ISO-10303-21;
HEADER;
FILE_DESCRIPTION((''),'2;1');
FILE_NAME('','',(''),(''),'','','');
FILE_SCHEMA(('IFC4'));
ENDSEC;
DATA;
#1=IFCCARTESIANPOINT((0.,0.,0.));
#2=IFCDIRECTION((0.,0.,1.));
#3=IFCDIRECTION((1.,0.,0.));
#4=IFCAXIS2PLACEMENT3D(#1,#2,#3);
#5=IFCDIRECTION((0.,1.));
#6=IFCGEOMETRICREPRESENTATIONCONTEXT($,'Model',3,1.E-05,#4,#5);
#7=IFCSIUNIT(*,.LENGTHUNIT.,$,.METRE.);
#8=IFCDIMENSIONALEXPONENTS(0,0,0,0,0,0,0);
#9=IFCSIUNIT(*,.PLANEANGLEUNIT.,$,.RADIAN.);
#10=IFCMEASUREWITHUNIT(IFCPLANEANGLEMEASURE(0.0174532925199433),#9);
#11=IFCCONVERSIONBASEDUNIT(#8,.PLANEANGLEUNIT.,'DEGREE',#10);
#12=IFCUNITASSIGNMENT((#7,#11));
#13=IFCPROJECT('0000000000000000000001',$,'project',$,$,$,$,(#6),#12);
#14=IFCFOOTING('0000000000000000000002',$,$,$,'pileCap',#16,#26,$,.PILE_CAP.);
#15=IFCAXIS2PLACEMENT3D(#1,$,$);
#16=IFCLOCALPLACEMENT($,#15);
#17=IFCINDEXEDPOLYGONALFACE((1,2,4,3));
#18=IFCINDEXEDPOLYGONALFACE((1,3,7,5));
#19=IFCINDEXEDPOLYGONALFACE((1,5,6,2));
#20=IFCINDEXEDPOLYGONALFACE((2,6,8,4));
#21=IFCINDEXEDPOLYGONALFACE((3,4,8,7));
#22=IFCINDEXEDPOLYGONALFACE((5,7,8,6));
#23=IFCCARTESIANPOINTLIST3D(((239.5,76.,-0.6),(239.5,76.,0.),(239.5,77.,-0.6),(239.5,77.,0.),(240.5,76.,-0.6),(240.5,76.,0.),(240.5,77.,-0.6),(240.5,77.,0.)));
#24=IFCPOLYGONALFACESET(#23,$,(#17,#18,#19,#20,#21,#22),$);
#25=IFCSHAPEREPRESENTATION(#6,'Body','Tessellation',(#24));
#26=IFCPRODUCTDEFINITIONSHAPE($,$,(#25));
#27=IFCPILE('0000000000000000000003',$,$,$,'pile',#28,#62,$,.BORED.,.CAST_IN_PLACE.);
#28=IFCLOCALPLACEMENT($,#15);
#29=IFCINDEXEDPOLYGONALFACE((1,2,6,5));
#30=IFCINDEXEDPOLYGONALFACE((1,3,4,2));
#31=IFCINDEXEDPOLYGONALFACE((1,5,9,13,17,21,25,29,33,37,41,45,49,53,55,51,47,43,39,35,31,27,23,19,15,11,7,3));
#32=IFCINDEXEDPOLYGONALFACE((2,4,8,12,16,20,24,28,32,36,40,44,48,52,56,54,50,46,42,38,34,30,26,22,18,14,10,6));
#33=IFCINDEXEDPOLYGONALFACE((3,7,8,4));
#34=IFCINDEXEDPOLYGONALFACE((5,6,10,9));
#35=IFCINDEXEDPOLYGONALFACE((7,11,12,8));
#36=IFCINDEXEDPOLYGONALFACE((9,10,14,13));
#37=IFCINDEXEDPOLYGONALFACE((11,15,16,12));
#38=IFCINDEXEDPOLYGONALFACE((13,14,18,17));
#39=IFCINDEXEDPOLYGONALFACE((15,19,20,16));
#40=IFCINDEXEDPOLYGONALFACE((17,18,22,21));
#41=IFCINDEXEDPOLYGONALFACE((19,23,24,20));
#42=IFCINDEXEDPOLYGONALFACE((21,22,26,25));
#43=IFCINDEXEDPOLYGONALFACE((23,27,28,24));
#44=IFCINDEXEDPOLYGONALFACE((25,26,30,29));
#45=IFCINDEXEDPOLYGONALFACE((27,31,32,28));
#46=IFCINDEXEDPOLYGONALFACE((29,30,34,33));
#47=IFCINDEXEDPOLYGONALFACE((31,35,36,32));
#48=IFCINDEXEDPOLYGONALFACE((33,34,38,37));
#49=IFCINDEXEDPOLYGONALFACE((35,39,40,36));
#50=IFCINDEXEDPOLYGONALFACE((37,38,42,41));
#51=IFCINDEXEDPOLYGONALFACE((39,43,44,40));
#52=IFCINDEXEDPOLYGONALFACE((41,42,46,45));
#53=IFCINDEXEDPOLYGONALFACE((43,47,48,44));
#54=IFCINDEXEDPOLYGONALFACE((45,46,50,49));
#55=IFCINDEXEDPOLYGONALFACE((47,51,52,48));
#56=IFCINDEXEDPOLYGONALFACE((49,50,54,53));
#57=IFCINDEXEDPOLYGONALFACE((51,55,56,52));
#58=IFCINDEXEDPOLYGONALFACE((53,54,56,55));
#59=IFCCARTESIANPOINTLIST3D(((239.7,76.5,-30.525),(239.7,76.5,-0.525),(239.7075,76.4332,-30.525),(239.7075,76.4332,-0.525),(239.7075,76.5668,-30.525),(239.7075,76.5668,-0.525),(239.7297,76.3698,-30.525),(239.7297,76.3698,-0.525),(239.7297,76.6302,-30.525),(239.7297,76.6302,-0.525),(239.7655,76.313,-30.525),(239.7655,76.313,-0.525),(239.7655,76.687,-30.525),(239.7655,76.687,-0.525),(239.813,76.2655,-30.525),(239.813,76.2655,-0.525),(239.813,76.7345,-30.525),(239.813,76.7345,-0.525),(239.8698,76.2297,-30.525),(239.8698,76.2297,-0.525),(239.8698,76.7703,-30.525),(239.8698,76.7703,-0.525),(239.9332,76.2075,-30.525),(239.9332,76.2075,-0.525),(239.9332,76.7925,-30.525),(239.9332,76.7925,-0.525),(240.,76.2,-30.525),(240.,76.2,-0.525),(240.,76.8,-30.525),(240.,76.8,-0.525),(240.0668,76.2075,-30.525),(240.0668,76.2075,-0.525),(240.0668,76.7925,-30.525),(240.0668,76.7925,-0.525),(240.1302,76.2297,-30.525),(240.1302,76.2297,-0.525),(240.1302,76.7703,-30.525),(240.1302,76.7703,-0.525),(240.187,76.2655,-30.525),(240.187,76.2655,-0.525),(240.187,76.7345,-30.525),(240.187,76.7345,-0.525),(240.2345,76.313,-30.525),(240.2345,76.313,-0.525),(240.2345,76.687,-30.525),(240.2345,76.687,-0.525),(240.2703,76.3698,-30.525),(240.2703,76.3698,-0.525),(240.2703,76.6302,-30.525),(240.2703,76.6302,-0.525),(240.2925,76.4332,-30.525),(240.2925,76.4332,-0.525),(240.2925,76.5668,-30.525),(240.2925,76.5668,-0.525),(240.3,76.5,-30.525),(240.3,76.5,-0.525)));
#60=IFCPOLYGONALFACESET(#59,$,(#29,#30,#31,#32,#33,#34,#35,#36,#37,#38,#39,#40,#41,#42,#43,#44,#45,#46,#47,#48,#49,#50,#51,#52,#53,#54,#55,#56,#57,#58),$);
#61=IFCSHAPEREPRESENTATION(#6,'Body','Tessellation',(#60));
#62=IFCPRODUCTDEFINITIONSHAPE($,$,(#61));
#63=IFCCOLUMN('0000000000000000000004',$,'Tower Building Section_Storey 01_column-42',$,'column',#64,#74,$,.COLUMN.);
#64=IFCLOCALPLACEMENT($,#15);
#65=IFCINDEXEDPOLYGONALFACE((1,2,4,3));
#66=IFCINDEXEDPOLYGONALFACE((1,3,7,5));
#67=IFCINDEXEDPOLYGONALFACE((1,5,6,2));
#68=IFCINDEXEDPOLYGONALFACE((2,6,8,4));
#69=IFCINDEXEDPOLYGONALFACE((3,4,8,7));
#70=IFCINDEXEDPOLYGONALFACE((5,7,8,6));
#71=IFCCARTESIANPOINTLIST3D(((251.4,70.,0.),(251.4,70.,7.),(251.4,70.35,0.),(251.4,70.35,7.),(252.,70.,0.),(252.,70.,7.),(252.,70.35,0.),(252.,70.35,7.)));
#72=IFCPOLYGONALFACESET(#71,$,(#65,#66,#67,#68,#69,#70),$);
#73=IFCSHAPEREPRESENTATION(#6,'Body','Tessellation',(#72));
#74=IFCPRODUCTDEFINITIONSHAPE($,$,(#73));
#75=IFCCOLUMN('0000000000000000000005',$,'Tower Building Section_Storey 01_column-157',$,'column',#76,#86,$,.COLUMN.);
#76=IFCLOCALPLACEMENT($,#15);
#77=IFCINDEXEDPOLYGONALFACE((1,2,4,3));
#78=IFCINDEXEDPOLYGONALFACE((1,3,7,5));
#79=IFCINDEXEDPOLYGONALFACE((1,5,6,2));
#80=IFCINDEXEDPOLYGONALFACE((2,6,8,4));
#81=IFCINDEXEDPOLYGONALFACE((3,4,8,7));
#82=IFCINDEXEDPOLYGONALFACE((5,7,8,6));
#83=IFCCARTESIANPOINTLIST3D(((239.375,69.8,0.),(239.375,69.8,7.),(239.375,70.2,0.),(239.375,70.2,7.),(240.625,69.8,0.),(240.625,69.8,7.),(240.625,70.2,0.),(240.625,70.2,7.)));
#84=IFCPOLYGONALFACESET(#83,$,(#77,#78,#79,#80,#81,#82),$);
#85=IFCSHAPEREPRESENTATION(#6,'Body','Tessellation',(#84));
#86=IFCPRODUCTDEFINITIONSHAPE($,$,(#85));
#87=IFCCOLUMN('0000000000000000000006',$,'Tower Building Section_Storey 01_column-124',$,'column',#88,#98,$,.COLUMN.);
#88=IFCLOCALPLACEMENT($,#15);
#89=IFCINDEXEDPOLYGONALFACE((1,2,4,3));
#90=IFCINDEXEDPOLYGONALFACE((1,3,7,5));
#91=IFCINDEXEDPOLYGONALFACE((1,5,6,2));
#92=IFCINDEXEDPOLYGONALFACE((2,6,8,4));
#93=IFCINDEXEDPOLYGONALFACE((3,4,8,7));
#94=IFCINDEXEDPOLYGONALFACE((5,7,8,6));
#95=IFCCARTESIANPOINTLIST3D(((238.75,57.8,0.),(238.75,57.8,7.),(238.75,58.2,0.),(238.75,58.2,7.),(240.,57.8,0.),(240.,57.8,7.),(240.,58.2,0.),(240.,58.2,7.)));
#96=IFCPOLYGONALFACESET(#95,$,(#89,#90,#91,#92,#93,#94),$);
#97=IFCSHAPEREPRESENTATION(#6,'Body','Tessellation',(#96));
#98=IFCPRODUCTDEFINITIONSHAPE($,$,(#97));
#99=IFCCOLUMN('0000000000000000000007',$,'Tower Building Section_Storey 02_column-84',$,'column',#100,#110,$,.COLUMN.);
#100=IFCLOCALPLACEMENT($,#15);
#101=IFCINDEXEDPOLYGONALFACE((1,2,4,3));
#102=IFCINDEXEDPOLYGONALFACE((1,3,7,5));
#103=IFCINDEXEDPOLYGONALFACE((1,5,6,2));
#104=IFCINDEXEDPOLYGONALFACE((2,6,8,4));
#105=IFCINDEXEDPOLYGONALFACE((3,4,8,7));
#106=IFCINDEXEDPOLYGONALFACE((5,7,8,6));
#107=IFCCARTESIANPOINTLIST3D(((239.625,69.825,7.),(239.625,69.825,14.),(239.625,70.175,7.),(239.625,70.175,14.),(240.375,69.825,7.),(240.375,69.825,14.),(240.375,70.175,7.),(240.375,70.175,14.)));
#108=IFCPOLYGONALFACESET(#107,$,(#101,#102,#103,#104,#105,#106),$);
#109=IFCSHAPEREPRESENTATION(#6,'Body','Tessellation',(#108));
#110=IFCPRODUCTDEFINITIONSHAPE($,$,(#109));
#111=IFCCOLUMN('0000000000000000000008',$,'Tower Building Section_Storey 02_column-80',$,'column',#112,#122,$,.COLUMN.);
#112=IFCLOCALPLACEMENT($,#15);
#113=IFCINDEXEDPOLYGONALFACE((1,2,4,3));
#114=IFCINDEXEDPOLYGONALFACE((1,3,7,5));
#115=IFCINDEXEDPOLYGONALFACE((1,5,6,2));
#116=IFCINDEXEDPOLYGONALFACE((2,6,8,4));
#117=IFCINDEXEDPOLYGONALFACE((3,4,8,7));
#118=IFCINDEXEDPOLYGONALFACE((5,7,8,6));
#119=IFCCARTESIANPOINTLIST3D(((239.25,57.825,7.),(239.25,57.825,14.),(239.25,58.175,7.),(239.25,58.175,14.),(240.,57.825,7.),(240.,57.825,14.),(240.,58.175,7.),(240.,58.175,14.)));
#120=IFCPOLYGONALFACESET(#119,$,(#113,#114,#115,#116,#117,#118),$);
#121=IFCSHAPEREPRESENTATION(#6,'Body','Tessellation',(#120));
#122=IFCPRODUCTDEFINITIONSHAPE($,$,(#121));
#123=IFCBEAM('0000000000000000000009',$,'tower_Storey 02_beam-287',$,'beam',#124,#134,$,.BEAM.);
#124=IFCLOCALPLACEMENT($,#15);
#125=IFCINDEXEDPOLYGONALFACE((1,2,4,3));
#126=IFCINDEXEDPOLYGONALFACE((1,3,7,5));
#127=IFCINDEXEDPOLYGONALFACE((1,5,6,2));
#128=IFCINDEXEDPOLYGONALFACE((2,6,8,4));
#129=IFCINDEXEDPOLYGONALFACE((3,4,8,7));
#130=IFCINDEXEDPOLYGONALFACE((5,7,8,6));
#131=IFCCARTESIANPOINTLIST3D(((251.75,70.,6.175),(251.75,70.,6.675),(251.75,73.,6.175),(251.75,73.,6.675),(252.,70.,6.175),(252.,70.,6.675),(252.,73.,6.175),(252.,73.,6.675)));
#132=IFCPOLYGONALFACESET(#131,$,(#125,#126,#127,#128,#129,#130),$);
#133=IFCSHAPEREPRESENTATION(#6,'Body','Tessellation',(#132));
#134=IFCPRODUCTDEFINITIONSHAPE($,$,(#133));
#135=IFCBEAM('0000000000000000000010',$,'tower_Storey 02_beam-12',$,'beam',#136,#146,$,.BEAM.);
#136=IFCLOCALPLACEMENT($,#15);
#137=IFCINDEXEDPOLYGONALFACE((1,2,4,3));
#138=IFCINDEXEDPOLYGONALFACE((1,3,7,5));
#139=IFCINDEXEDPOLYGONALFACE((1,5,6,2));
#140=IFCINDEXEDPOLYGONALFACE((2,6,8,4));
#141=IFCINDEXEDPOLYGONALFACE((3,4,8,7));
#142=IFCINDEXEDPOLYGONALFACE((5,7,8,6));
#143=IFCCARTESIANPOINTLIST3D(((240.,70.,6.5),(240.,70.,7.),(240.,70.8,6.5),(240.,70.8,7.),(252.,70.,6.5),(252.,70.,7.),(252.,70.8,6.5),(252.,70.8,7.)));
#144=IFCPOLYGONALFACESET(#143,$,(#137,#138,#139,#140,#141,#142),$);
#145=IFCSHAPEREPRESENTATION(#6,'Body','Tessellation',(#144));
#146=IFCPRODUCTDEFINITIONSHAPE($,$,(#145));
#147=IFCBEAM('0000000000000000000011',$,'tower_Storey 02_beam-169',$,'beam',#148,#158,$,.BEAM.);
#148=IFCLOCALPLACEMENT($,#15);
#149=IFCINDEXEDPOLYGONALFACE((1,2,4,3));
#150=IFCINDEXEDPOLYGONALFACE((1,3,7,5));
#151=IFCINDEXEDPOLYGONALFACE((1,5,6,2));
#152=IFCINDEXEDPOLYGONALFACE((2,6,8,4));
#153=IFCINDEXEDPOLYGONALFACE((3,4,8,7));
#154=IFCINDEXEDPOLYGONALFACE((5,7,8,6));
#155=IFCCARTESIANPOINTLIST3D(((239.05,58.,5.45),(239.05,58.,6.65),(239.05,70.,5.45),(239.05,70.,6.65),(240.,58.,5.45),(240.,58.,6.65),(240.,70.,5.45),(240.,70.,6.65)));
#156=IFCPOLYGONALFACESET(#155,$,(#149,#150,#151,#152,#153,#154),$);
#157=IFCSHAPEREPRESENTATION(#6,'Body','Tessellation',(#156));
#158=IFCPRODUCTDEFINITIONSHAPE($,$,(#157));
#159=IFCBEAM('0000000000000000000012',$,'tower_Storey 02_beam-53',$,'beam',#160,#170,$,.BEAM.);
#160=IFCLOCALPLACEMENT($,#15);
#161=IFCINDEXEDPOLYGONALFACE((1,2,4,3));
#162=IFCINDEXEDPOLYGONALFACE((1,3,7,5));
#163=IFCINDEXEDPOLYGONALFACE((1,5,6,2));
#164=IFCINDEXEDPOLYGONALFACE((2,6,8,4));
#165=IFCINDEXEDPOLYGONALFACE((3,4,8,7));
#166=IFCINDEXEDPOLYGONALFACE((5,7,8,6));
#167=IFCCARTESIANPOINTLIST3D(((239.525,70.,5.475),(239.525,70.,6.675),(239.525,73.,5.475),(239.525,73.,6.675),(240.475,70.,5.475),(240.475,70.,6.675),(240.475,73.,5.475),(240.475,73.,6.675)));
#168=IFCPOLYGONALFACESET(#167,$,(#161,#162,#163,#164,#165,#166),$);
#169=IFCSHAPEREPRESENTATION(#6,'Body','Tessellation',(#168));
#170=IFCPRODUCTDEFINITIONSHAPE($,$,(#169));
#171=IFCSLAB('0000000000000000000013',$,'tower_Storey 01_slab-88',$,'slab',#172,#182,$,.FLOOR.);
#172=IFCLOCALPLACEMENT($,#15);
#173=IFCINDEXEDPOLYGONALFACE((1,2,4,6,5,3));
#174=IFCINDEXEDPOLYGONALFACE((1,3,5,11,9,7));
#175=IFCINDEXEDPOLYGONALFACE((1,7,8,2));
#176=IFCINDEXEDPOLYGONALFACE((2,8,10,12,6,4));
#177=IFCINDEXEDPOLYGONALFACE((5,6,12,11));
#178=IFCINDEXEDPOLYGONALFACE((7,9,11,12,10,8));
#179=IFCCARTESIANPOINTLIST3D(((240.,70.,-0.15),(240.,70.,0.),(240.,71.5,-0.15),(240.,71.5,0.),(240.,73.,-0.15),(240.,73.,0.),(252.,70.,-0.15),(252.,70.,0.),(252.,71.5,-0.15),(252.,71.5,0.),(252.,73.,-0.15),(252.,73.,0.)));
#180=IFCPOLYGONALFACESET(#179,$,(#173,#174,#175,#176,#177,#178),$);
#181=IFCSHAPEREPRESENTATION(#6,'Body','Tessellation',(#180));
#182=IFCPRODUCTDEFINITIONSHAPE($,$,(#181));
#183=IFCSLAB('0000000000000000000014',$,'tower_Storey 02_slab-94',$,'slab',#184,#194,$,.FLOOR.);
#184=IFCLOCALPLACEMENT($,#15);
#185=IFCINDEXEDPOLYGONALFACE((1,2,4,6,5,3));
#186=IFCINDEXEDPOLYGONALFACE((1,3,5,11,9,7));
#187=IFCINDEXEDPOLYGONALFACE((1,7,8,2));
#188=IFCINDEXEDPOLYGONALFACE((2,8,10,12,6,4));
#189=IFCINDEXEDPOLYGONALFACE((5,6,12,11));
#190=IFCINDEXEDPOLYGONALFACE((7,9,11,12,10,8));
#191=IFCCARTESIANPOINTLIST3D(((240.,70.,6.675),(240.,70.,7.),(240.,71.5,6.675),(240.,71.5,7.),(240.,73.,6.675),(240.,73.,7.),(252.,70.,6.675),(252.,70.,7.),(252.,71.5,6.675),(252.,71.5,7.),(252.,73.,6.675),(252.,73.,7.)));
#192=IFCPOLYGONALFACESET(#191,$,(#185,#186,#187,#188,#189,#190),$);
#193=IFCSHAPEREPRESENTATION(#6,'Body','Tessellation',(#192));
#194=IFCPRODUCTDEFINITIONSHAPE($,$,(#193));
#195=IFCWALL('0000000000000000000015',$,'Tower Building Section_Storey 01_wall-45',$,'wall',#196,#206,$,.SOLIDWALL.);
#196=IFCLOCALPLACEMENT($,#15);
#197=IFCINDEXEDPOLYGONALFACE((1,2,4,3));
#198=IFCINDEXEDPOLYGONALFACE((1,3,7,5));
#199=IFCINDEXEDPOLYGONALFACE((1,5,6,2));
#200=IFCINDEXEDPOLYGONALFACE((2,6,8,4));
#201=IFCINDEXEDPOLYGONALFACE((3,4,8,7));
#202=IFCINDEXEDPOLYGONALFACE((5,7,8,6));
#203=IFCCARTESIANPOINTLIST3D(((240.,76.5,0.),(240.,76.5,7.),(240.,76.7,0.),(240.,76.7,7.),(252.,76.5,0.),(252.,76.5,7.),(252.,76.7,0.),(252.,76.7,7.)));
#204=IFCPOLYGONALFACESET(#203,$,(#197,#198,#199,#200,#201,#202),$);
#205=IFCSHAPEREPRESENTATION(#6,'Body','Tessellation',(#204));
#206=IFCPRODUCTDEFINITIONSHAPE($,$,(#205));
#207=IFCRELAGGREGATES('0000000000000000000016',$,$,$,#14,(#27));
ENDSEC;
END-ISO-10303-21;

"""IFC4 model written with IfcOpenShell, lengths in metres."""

from ifc_helpers import new_model, entity, si_unit, converted_unit, direction, frame, origin_with_axes, place, context, project, polyline, circle_curve, parameter, trimmed, segment, composite_curve, outline, extrude, element, aggregate, save


model = new_model("IFC4")

# Units and contexts
model_context = context("Model", 3, precision=1e-05, world=origin_with_axes(), true_north=direction((0.0, 1.0)))
ifc_project = project(units=[si_unit("LENGTHUNIT", "METRE"), converted_unit("PLANEANGLEUNIT", "DEGREE", entity("IfcPlaneAngleMeasure", 0.0174532925199433), si_unit("PLANEANGLEUNIT", "RADIAN"), dimensions=[0, 0, 0, 0, 0, 0, 0])], contexts=[model_context])

# Footing
placement_1 = place(None, origin_with_axes())
placement_2 = place(placement_1, origin_with_axes())
footing_1_placement = place(placement_2, frame((240.0, 76.5, -0.6), z_axis=(0.0, 0.0, 1.0), x_axis=(1.0, 0.0, 0.0)))
footing_1 = element("IfcFooting", 1, at=footing_1_placement, ObjectType="pileCap", PredefinedType="PILE_CAP", context=model_context, body=[
    extrude(outline(polyline([(0.5, -0.5, 0.0), (0.5, 0.5, 0.0), (-0.5, 0.5, 0.0), (-0.5, -0.5, 0.0), (0.5, -0.5, 0.0)])), origin_with_axes(), (0.0, 0.0, 1.0), 0.6),
])

# Pile
pile_1_placement = place(footing_1_placement, frame((0.0, 0.0, -29.925), z_axis=(0.0, 0.0, 1.0), x_axis=(1.0, 0.0, 0.0)))
pile_1 = element("IfcPile", 2, at=pile_1_placement, ObjectType="pile", ConstructionType="CAST_IN_PLACE", PredefinedType="BORED", context=model_context, body=[
    extrude(outline(composite_curve([segment(trimmed(circle_curve(origin_with_axes(), 0.3), [parameter(0.0)], [parameter(360.0)], True, "PARAMETER"), True, "CONTINUOUS")], self_intersect=False)), origin_with_axes(), (0.0, 0.0, 1.0), 30.0),
])
aggregate(footing_1, [pile_1])

# Columns
column_placement = place(placement_2, frame((251.7, 70.175, 0.0), z_axis=(0.0, 0.0, 1.0), x_axis=(1.0, 0.0, 0.0)))
element("IfcColumn", 3, at=column_placement, Name="Tower Building Section_Storey 01_column-42", ObjectType="column", PredefinedType="COLUMN", context=model_context, body=[
    extrude(outline(polyline([(-0.3, -0.175, 0.0), (0.3, -0.175, 0.0), (0.3, 0.175, 0.0), (-0.3, 0.175, 0.0), (-0.3, -0.175, 0.0)])), origin_with_axes(), (0.0, 0.0, 1.0), 7.0),
])
for number, where, z_axis, x_axis, name in (
    (4, (240.0, 70.0, 0.0), (0.0, 0.0, 1.0), (1.0, 0.0, 0.0), "Tower Building Section_Storey 01_column-157"),
    (5, (239.375, 58.0, 0.0), (0.0, 0.0, 1.0), (1.0, 0.0, 0.0), "Tower Building Section_Storey 01_column-124"),
):
    element("IfcColumn", number, at=place(placement_2, frame(where, z_axis=z_axis, x_axis=x_axis)), Name=name, ObjectType="column", PredefinedType="COLUMN", context=model_context, body=[
        extrude(outline(polyline([(-0.625, -0.2, 0.0), (0.625, -0.2, 0.0), (0.625, 0.2, 0.0), (-0.625, 0.2, 0.0), (-0.625, -0.2, 0.0)])), origin_with_axes(), (0.0, 0.0, 1.0), 7.0),
    ])
placement_3 = place(placement_1, frame((0.0, 0.0, 7.0), z_axis=(0.0, 0.0, 1.0), x_axis=(1.0, 0.0, 0.0)))
for number, where, z_axis, x_axis, name in (
    (6, (240.0, 70.0, 0.0), (0.0, 0.0, 1.0), (1.0, 0.0, 0.0), "Tower Building Section_Storey 02_column-84"),
    (7, (239.625, 58.0, 0.0), (0.0, 0.0, 1.0), (1.0, 0.0, 0.0), "Tower Building Section_Storey 02_column-80"),
):
    element("IfcColumn", number, at=place(placement_3, frame(where, z_axis=z_axis, x_axis=x_axis)), Name=name, ObjectType="column", PredefinedType="COLUMN", context=model_context, body=[
        extrude(outline(polyline([(-0.375, -0.175, 0.0), (0.375, -0.175, 0.0), (0.375, 0.175, 0.0), (-0.375, 0.175, 0.0), (-0.375, -0.175, 0.0)])), origin_with_axes(), (0.0, 0.0, 1.0), 7.0),
    ])

# Beams
beam_1_placement = place(placement_3, frame((251.875, 70.0, -0.575), z_axis=(0.0, 1.0, 0.0), x_axis=(-1.0, 0.0, 0.0)))
element("IfcBeam", 8, at=beam_1_placement, Name="tower_Storey 02_beam-287", ObjectType="beam", PredefinedType="BEAM", context=model_context, body=[
    extrude(outline(polyline([(0.125, 0.25, 0.0), (-0.125, 0.25, 0.0), (-0.125, -0.25, 0.0), (0.125, -0.25, 0.0), (0.125, 0.25, 0.0)])), origin_with_axes(), (0.0, 0.0, 1.0), 3.0),
])
beam_2_placement = place(placement_3, frame((240.0, 70.4, -0.25), z_axis=(1.0, 0.0, 0.0), x_axis=(0.0, 1.0, 0.0)))
element("IfcBeam", 9, at=beam_2_placement, Name="tower_Storey 02_beam-12", ObjectType="beam", PredefinedType="BEAM", context=model_context, body=[
    extrude(outline(polyline([(0.4, 0.25, 0.0), (-0.4, 0.25, 0.0), (-0.4, -0.25, 0.0), (0.4, -0.25, 0.0), (0.4, 0.25, 0.0)])), origin_with_axes(), (0.0, 0.0, 1.0), 12.0),
])
beam_3_placement = place(placement_3, frame((239.525, 58.0, -0.95), z_axis=(0.0, 1.0, 0.0), x_axis=(-1.0, 0.0, 0.0)))
element("IfcBeam", 10, at=beam_3_placement, Name="tower_Storey 02_beam-169", ObjectType="beam", PredefinedType="BEAM", context=model_context, body=[
    extrude(outline(polyline([(0.475, 0.6, 0.0), (-0.475, 0.6, 0.0), (-0.475, -0.6, 0.0), (0.475, -0.6, 0.0), (0.475, 0.6, 0.0)])), origin_with_axes(), (0.0, 0.0, 1.0), 12.0),
])
beam_4_placement = place(placement_3, frame((240.0, 70.0, -0.925), z_axis=(0.0, 1.0, 0.0), x_axis=(-1.0, 0.0, 0.0)))
element("IfcBeam", 11, at=beam_4_placement, Name="tower_Storey 02_beam-53", ObjectType="beam", PredefinedType="BEAM", context=model_context, body=[
    extrude(outline(polyline([(0.475, 0.6, 0.0), (-0.475, 0.6, 0.0), (-0.475, -0.6, 0.0), (0.475, -0.6, 0.0), (0.475, 0.6, 0.0)])), origin_with_axes(), (0.0, 0.0, 1.0), 3.0),
])

# Slabs
slab_1_placement = place(placement_2, frame((246.0, 71.5, -0.15), z_axis=(0.0, 0.0, 1.0), x_axis=(1.0, 0.0, 0.0)))
element("IfcSlab", 12, at=slab_1_placement, Name="tower_Storey 01_slab-88", ObjectType="slab", PredefinedType="FLOOR", context=model_context, body=[
    extrude(outline(polyline([(-6.0, 0.0, 0.0), (-6.0, -1.5, 0.0), (6.0, -1.5, 0.0), (6.0, 0.0, 0.0), (6.0, 1.5, 0.0), (-6.0, 1.5, 0.0), (-6.0, 0.0, 0.0)])), origin_with_axes(), (0.0, 0.0, 1.0), 0.15),
])
slab_2_placement = place(placement_3, frame((246.0, 71.5, -0.325), z_axis=(0.0, 0.0, 1.0), x_axis=(1.0, 0.0, 0.0)))
element("IfcSlab", 13, at=slab_2_placement, Name="tower_Storey 02_slab-94", ObjectType="slab", PredefinedType="FLOOR", context=model_context, body=[
    extrude(outline(polyline([(-6.0, 0.0, 0.0), (-6.0, -1.5, 0.0), (6.0, -1.5, 0.0), (6.0, 0.0, 0.0), (6.0, 1.5, 0.0), (-6.0, 1.5, 0.0), (-6.0, 0.0, 0.0)])), origin_with_axes(), (0.0, 0.0, 1.0), 0.325),
])

# Wall
wall_1_placement = place(placement_2, frame((246.0, 76.5, 3.5), z_axis=(0.0, 1.0, 0.0), x_axis=(0.0, 0.0, 1.0)))
element("IfcWall", 14, at=wall_1_placement, Name="Tower Building Section_Storey 01_wall-45", ObjectType="wall", PredefinedType="SOLIDWALL", context=model_context, body=[
    extrude(outline(polyline([(-3.5, -6.0, 0.0), (3.5, -6.0, 0.0), (3.5, 6.0, 0.0), (-3.5, 6.0, 0.0), (-3.5, -6.0, 0.0)])), origin_with_axes(), (0.0, 0.0, 1.0), 0.2),
])

save(model, "model.ifc")
